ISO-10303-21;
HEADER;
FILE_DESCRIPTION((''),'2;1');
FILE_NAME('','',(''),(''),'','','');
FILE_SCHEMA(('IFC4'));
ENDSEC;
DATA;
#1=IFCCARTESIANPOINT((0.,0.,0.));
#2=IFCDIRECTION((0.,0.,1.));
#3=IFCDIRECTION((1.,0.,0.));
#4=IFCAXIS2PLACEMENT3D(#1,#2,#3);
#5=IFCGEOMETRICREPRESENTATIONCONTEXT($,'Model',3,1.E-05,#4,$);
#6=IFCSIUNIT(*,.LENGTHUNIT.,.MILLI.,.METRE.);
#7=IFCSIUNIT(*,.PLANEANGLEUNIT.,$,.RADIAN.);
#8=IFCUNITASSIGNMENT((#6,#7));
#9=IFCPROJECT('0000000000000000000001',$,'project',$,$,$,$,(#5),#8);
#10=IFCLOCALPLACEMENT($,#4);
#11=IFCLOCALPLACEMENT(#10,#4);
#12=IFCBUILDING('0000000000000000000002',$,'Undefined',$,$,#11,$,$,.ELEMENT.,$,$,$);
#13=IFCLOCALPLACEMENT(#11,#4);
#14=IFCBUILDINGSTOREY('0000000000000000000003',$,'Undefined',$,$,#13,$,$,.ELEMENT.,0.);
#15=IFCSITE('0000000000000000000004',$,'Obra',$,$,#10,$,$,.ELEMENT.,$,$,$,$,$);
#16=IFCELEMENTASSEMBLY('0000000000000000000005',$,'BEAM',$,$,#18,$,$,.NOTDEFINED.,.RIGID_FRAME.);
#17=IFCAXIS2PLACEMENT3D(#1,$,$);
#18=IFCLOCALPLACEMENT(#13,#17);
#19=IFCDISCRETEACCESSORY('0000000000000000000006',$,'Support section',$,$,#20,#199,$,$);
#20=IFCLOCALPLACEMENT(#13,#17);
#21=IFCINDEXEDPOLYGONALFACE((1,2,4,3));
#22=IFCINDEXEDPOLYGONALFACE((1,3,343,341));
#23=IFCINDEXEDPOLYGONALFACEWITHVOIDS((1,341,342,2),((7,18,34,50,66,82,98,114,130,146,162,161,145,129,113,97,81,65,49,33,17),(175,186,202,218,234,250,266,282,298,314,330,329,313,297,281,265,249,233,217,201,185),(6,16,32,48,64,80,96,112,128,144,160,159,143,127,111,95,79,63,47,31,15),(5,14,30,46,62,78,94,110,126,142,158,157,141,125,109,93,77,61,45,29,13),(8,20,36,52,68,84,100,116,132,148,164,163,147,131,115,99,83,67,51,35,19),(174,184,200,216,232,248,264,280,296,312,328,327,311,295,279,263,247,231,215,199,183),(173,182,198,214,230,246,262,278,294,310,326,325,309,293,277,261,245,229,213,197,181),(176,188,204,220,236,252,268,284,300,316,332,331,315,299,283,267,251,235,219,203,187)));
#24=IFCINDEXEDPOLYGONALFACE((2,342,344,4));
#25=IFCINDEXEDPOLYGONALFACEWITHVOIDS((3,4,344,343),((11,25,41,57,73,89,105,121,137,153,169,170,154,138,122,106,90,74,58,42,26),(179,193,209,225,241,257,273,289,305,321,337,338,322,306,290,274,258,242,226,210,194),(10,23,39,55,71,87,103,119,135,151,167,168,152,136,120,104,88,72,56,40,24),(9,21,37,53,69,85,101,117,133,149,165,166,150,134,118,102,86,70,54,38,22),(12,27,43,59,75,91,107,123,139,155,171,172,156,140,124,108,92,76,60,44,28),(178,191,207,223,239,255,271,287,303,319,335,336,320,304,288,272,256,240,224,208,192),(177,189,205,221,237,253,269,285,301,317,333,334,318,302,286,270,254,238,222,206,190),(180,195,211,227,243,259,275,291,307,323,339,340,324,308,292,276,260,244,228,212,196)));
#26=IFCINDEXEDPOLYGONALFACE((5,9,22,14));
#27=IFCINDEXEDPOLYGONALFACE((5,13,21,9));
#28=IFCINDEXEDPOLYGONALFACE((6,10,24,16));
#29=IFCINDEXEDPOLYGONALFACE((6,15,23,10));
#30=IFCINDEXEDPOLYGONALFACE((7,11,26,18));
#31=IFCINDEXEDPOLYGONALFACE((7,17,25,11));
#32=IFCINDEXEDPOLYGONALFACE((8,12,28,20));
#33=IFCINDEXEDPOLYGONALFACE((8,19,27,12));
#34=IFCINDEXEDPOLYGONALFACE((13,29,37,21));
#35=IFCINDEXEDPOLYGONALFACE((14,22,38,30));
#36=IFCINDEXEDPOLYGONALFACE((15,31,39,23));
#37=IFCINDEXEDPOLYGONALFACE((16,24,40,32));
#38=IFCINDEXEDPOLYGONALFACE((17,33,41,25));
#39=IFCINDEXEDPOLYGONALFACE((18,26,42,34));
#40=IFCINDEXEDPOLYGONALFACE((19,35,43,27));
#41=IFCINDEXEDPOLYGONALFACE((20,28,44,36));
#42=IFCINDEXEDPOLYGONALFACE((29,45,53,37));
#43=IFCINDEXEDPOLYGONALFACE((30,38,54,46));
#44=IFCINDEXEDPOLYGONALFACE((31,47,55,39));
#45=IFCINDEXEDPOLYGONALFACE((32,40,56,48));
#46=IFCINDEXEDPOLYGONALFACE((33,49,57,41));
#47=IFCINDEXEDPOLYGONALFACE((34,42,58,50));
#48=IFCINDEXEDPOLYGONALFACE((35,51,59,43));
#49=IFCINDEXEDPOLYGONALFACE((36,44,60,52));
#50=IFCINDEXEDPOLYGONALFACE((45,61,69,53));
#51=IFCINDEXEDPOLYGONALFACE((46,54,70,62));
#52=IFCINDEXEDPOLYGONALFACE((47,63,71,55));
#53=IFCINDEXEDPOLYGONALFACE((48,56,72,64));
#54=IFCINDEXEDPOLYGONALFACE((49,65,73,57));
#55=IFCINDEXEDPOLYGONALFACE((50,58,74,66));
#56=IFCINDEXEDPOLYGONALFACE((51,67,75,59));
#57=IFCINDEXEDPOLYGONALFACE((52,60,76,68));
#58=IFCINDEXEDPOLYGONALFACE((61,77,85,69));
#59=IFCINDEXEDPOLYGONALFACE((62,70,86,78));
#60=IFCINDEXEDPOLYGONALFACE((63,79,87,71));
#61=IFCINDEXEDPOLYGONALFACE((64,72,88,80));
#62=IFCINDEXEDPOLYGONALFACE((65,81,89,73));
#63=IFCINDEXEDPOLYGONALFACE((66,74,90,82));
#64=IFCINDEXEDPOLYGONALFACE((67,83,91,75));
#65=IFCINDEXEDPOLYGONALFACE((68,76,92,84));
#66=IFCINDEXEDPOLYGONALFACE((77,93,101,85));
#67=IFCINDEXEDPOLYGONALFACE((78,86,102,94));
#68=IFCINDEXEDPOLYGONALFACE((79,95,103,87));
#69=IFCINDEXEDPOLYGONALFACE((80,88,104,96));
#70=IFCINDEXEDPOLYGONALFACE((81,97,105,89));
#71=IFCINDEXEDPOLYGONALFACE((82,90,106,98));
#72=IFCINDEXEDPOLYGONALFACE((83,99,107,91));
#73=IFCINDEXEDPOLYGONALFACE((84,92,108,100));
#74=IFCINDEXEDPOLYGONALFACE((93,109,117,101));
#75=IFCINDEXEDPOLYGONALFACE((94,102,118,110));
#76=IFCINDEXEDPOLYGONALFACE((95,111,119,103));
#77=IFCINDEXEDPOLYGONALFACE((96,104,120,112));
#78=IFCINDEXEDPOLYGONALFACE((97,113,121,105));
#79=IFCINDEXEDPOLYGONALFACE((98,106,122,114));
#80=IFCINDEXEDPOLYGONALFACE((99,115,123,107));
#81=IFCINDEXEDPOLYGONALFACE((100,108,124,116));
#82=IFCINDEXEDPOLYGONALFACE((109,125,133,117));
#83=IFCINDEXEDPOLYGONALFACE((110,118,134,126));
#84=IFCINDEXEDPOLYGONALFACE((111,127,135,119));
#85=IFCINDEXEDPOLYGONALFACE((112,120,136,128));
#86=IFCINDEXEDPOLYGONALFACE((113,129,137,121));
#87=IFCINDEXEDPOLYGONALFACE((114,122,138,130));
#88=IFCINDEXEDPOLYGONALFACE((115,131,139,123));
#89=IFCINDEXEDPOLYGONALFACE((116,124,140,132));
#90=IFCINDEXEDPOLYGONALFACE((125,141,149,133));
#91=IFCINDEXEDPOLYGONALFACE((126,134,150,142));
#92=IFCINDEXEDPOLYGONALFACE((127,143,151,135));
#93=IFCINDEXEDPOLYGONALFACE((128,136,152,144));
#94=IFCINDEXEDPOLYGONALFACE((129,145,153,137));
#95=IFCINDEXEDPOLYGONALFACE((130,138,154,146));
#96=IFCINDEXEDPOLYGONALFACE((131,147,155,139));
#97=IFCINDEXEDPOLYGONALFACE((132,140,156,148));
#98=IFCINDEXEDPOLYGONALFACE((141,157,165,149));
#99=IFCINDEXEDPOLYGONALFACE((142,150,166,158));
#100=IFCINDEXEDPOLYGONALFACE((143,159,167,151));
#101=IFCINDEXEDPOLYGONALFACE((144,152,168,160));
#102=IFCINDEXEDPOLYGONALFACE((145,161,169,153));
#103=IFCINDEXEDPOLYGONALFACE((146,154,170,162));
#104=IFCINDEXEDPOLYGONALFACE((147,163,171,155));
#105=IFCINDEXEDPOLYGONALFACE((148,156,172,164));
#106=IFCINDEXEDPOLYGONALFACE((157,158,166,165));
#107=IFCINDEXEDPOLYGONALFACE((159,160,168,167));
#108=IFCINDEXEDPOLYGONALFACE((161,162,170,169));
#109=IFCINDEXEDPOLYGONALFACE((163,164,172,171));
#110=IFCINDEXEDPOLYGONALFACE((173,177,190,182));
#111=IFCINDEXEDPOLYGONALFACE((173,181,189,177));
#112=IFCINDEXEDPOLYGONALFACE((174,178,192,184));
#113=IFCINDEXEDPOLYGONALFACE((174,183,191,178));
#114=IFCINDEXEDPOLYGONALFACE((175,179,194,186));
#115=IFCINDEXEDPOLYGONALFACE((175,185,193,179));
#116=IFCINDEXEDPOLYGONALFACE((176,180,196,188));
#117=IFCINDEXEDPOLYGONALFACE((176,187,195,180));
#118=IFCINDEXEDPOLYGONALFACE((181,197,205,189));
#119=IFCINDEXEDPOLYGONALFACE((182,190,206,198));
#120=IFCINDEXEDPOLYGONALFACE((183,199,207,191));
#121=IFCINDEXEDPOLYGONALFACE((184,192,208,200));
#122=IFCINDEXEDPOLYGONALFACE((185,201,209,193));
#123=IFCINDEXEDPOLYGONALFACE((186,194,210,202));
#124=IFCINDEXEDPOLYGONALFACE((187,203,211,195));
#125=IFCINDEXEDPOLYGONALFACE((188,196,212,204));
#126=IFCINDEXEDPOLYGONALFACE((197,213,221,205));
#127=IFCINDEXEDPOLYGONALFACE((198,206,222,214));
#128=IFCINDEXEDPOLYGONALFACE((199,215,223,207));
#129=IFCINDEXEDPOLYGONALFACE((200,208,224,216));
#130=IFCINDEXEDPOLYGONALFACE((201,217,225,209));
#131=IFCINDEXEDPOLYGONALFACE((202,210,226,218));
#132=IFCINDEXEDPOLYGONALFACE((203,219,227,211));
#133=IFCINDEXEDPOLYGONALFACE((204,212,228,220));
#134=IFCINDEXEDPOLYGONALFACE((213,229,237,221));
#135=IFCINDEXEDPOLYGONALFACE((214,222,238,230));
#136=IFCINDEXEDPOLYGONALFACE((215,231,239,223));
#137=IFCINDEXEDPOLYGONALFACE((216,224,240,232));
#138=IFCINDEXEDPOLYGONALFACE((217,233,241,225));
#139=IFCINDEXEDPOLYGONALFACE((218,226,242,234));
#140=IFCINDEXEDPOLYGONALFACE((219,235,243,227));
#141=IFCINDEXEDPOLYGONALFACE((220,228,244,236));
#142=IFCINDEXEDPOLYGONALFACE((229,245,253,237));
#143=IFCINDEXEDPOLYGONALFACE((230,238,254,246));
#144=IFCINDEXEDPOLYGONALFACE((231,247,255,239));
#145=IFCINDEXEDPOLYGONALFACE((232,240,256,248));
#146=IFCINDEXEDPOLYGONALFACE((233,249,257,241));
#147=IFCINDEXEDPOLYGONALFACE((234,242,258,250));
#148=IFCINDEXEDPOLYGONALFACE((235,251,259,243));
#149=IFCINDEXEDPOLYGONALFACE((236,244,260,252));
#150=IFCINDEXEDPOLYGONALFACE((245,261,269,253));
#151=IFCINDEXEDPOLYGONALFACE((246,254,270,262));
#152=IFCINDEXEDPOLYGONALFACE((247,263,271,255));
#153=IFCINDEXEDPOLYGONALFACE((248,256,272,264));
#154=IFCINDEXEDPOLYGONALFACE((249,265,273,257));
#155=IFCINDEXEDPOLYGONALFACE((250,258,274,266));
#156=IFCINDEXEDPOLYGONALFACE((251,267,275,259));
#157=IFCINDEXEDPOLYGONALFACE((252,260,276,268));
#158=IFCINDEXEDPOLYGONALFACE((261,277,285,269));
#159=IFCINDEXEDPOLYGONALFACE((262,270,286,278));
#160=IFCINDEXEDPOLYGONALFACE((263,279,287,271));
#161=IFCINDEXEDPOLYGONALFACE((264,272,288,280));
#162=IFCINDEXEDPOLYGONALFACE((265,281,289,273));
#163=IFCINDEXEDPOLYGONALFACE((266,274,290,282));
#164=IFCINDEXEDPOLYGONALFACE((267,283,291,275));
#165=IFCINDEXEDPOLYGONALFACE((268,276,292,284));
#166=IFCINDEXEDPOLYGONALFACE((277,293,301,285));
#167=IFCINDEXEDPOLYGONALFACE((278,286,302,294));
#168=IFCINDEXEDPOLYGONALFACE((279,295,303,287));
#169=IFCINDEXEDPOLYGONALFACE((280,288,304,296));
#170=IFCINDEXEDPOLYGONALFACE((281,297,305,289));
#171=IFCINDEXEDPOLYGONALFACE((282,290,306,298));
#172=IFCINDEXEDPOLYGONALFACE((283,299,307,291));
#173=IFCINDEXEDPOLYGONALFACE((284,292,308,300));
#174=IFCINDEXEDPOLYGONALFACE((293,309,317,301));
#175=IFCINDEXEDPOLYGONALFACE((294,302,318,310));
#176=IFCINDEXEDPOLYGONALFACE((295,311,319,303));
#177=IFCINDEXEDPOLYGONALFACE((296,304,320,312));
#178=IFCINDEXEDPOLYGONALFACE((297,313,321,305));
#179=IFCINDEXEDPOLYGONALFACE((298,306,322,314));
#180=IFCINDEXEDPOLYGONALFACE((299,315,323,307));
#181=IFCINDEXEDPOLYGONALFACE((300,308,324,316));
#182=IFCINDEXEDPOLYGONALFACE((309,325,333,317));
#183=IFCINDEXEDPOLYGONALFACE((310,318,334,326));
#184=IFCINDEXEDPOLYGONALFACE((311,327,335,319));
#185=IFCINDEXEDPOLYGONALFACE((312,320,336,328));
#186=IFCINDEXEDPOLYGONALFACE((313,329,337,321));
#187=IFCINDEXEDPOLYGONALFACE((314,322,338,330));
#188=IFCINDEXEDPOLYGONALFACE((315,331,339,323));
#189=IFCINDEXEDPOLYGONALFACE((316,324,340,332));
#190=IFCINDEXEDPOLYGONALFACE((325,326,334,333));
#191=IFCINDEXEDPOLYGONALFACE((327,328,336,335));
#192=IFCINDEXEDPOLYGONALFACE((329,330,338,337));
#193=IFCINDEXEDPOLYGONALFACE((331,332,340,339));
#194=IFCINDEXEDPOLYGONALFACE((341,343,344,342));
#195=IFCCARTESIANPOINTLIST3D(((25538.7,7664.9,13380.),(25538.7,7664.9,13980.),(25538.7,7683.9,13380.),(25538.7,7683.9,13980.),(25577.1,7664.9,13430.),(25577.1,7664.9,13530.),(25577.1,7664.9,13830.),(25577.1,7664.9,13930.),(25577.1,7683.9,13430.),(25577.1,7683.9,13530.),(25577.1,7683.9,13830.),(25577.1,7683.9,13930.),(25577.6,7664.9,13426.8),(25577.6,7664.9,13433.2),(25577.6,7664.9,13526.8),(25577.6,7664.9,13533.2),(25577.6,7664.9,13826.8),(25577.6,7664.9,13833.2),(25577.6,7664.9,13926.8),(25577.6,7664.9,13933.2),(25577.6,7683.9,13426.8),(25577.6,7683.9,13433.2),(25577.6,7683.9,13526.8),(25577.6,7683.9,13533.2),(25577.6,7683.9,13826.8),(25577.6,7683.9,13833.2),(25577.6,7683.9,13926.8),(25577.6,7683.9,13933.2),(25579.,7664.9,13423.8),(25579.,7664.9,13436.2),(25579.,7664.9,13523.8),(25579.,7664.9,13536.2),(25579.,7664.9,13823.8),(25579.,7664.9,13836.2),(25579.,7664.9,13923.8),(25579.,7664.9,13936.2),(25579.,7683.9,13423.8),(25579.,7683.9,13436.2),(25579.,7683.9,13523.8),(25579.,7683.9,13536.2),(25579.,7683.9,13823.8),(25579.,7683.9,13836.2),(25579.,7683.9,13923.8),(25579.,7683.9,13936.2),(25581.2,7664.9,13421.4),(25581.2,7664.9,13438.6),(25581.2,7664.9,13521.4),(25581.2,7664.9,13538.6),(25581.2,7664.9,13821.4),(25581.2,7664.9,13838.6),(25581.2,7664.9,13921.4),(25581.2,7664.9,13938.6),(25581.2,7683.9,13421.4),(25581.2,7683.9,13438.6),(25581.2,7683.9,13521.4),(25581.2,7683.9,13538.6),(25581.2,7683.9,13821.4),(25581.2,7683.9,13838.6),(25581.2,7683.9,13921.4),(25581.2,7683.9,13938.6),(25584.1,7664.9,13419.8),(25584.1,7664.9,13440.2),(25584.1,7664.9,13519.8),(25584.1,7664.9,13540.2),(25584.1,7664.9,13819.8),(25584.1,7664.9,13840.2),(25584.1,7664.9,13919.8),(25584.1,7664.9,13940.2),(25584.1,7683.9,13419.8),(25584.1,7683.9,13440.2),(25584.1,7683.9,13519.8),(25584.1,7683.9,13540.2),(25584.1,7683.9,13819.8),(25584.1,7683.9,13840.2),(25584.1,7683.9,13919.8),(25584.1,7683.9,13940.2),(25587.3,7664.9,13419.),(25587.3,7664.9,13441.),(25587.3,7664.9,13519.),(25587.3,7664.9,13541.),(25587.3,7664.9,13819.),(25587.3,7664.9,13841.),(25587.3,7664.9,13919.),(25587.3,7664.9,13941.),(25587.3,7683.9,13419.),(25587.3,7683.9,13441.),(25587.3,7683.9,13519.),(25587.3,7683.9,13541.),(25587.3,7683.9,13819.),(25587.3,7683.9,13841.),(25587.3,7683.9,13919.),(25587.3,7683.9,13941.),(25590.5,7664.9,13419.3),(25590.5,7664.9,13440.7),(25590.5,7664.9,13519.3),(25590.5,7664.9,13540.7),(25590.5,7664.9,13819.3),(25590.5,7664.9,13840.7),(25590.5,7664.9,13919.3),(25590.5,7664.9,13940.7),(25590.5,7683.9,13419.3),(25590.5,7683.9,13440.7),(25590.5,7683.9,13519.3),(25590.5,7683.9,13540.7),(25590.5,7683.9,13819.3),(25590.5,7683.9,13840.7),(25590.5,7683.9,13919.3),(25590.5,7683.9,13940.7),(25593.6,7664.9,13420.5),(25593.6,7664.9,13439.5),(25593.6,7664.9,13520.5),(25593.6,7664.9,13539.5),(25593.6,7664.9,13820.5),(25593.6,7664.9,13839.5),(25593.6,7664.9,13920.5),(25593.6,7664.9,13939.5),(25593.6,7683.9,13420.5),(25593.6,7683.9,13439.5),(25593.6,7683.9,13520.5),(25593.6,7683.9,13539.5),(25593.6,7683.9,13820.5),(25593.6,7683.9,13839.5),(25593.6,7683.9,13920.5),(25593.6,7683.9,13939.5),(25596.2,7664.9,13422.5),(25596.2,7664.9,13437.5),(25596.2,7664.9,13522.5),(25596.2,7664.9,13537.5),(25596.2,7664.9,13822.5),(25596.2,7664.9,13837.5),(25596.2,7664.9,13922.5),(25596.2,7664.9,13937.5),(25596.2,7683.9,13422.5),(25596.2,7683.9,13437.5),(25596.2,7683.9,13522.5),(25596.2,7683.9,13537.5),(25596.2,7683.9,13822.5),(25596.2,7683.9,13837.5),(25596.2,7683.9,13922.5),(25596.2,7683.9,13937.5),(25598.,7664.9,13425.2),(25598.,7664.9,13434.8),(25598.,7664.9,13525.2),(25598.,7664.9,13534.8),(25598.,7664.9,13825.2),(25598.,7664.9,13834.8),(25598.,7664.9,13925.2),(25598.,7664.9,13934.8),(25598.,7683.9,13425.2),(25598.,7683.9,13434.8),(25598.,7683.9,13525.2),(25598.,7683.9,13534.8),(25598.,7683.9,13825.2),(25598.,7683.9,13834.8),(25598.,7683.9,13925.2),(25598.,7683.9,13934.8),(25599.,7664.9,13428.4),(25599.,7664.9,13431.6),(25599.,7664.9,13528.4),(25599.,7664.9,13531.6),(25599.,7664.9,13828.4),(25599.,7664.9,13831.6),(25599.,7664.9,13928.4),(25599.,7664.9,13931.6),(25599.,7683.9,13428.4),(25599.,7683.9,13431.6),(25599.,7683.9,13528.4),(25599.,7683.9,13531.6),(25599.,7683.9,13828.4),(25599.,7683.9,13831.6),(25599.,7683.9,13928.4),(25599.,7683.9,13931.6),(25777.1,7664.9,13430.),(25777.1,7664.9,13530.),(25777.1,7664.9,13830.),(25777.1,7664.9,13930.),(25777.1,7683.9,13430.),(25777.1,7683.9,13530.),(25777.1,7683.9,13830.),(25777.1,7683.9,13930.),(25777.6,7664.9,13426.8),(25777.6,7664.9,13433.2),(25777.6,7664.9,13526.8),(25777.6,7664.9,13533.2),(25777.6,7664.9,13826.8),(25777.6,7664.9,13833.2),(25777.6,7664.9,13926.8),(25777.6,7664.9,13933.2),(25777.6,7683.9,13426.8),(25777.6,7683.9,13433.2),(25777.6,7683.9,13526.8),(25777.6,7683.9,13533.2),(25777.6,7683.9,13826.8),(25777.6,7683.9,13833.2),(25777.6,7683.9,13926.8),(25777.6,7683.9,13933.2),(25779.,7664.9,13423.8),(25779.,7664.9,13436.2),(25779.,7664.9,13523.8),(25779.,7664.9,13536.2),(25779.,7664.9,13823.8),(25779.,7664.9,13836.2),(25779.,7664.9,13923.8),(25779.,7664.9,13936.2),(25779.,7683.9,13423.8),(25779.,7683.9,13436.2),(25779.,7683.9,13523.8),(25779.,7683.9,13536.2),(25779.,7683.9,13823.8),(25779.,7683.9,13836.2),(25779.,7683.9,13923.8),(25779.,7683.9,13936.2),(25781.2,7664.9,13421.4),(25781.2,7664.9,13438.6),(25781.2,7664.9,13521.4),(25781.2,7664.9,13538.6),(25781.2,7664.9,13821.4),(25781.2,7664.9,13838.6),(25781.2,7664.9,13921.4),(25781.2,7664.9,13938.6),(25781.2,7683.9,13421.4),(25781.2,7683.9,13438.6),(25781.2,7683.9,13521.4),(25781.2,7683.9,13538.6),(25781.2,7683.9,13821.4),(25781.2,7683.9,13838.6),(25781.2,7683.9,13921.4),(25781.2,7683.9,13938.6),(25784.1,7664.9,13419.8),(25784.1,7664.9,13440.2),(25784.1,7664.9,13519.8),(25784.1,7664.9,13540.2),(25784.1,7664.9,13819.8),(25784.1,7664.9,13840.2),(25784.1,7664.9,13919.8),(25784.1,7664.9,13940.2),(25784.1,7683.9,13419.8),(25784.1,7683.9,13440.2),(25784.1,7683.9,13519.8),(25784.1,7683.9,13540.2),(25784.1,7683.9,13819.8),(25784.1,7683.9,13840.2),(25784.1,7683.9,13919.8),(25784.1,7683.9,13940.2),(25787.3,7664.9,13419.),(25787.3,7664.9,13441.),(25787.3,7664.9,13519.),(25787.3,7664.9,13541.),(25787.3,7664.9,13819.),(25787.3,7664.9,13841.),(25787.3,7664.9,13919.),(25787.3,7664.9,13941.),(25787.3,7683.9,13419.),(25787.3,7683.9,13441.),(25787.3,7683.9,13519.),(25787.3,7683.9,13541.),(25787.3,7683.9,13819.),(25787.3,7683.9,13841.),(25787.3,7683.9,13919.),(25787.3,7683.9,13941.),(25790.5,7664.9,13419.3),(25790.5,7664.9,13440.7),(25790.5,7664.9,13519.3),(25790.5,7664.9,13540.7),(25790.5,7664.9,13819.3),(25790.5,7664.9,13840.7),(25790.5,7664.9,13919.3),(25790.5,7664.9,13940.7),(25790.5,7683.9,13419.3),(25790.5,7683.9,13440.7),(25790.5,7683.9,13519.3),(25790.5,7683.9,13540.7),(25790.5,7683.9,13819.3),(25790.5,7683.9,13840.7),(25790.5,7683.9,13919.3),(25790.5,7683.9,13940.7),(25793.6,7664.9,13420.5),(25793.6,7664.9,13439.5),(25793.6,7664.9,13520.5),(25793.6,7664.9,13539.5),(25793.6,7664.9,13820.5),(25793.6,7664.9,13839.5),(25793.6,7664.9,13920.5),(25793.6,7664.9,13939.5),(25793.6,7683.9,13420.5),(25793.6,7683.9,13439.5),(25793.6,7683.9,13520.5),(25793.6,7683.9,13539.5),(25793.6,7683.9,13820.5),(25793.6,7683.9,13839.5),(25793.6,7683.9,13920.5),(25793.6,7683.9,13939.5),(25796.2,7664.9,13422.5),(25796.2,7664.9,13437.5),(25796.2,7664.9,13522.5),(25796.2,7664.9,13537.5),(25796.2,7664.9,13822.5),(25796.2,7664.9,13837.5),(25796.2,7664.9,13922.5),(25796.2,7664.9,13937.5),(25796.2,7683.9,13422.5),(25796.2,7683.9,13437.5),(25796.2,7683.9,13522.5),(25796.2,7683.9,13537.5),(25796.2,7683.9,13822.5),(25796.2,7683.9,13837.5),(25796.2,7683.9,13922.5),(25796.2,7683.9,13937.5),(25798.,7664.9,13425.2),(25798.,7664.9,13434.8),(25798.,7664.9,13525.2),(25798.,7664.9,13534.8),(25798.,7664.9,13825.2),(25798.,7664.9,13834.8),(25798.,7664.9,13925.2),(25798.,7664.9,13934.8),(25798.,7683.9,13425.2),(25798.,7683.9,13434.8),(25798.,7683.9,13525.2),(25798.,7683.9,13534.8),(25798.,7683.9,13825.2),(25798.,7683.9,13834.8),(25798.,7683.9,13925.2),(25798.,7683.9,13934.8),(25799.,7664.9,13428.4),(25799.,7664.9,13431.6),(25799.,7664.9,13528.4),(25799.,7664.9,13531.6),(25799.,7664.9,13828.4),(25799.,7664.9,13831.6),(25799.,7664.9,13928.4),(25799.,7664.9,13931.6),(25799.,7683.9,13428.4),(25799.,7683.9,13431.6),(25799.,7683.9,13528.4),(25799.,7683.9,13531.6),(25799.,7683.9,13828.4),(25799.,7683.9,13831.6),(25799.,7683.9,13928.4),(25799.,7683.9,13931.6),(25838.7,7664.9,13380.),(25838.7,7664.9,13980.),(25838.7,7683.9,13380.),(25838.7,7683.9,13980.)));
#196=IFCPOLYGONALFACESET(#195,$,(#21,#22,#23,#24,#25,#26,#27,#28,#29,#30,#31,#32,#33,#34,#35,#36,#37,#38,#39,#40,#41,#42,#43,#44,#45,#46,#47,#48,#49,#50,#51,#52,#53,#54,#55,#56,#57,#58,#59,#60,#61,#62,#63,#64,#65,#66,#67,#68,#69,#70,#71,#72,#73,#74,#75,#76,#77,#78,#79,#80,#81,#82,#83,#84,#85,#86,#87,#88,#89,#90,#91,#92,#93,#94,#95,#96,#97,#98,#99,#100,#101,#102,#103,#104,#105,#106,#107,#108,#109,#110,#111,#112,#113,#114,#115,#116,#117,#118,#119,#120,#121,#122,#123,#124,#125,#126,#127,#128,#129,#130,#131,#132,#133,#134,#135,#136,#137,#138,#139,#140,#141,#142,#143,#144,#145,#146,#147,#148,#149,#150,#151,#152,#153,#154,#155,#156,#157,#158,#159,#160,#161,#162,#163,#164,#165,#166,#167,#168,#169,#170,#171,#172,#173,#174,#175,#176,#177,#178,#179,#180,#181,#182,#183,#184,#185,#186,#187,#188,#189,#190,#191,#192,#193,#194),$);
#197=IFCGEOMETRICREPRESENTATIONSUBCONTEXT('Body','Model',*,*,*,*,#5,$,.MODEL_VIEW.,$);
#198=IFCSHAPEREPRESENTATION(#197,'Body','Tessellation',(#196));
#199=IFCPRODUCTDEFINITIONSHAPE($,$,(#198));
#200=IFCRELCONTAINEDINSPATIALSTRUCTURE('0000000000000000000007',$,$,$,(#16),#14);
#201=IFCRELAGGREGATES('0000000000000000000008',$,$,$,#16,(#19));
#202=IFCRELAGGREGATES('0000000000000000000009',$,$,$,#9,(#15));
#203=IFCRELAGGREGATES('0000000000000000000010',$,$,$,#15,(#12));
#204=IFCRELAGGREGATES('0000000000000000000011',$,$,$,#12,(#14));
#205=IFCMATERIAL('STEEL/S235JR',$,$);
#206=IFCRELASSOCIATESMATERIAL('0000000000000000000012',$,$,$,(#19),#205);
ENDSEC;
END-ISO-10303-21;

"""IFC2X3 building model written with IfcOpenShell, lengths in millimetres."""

from ifc_helpers import new_model, si_unit, frame, origin_with_axes, origin_2d_with_axis, place, context, subcontext, project, spatial, rectangle, circle, extrude, source, transform, mapped, material, element, aggregate, save


model = new_model("IFC2X3")

# Units and contexts
model_context = context("Model", 3, precision=1e-05, world=origin_with_axes())
body_context = subcontext(model_context, "Body", "Model", "MODEL_VIEW")
ifc_project = project(units=[si_unit("LENGTHUNIT", "METRE", prefix="MILLI"), si_unit("PLANEANGLEUNIT", "RADIAN")], contexts=[model_context])

# Site, building, storey
site_placement = place(None, origin_with_axes())
site = spatial("IfcSite", under=ifc_project, at=site_placement, Name="Obra", CompositionType="ELEMENT")
building_placement = place(site_placement, origin_with_axes())
building = spatial("IfcBuilding", under=site, at=building_placement, Name="Undefined", CompositionType="ELEMENT")
storey_placement = place(building_placement, origin_with_axes())
storey = spatial("IfcBuildingStorey", under=building, at=storey_placement, Name="Undefined", CompositionType="ELEMENT", Elevation=0.0)

# Shared definitions
ifc_material_1 = material(Name="STEEL/S235JR")

# Element assembly
shared_shape_1 = source(origin_with_axes(), body_context, "Body", "SweptSolid", [
    extrude(circle(Radius=11.0, at=origin_2d_with_axis()), frame((0.0, -19.1, 0.0), z_axis=(0.0, 1.0, 0.0), x_axis=(1.0, 0.0, 0.0)), (0.0, 0.0, 1.0), 19.2),
])
assembly_1_placement = place(storey_placement, origin_with_axes())
assembly_1 = element("IfcElementAssembly", 1, at=assembly_1_placement, inside=storey, Name="BEAM", AssemblyPlace="NOTDEFINED", PredefinedType="RIGID_FRAME")

# Discrete accessory, opening
discrete_accessory_1_placement = place(assembly_1_placement, frame((25538.7, 7674.4, 13680.0), z_axis=(0.0, 0.0, 1.0), x_axis=(1.0, 0.0, 0.0)))
discrete_accessory_1 = element("IfcDiscreteAccessory", 2, at=discrete_accessory_1_placement, material=ifc_material_1, Name="Support section", context=body_context, shape_type="SweptSolid", body=[
    extrude(rectangle(XDim=19.0, YDim=600.0, at=origin_2d_with_axis()), frame((300.0, 0.0, 0.0), z_axis=(-1.0, 0.0, 0.0), x_axis=(0.0, -1.0, 0.0)), (0.0, 0.0, 1.0), 300.0),
])
opening_1_placement = place(assembly_1_placement, frame((25838.2, 7664.9, 13680.0), z_axis=(0.0, 0.0, 1.0), x_axis=(-1.0, 0.0, 0.0)))
element("IfcOpeningElement", 3, at=opening_1_placement, cuts=discrete_accessory_1, ObjectType="Opening", context=body_context, shape_type="MappedRepresentation", body=[
    mapped(shared_shape_1, transform((50.1, 0.0, -250.0))),
    mapped(shared_shape_1, transform((50.1, 0.0, -150.0))),
    mapped(shared_shape_1, transform((50.1, 0.0, 150.0))),
    mapped(shared_shape_1, transform((50.1, 0.0, 250.0))),
    mapped(shared_shape_1, transform((250.1, 0.0, -250.0))),
    mapped(shared_shape_1, transform((250.1, 0.0, -150.0))),
    mapped(shared_shape_1, transform((250.1, 0.0, 150.0))),
    mapped(shared_shape_1, transform((250.1, 0.0, 250.0))),
])

aggregate(assembly_1, [discrete_accessory_1])

save(model, "model.ifc")
